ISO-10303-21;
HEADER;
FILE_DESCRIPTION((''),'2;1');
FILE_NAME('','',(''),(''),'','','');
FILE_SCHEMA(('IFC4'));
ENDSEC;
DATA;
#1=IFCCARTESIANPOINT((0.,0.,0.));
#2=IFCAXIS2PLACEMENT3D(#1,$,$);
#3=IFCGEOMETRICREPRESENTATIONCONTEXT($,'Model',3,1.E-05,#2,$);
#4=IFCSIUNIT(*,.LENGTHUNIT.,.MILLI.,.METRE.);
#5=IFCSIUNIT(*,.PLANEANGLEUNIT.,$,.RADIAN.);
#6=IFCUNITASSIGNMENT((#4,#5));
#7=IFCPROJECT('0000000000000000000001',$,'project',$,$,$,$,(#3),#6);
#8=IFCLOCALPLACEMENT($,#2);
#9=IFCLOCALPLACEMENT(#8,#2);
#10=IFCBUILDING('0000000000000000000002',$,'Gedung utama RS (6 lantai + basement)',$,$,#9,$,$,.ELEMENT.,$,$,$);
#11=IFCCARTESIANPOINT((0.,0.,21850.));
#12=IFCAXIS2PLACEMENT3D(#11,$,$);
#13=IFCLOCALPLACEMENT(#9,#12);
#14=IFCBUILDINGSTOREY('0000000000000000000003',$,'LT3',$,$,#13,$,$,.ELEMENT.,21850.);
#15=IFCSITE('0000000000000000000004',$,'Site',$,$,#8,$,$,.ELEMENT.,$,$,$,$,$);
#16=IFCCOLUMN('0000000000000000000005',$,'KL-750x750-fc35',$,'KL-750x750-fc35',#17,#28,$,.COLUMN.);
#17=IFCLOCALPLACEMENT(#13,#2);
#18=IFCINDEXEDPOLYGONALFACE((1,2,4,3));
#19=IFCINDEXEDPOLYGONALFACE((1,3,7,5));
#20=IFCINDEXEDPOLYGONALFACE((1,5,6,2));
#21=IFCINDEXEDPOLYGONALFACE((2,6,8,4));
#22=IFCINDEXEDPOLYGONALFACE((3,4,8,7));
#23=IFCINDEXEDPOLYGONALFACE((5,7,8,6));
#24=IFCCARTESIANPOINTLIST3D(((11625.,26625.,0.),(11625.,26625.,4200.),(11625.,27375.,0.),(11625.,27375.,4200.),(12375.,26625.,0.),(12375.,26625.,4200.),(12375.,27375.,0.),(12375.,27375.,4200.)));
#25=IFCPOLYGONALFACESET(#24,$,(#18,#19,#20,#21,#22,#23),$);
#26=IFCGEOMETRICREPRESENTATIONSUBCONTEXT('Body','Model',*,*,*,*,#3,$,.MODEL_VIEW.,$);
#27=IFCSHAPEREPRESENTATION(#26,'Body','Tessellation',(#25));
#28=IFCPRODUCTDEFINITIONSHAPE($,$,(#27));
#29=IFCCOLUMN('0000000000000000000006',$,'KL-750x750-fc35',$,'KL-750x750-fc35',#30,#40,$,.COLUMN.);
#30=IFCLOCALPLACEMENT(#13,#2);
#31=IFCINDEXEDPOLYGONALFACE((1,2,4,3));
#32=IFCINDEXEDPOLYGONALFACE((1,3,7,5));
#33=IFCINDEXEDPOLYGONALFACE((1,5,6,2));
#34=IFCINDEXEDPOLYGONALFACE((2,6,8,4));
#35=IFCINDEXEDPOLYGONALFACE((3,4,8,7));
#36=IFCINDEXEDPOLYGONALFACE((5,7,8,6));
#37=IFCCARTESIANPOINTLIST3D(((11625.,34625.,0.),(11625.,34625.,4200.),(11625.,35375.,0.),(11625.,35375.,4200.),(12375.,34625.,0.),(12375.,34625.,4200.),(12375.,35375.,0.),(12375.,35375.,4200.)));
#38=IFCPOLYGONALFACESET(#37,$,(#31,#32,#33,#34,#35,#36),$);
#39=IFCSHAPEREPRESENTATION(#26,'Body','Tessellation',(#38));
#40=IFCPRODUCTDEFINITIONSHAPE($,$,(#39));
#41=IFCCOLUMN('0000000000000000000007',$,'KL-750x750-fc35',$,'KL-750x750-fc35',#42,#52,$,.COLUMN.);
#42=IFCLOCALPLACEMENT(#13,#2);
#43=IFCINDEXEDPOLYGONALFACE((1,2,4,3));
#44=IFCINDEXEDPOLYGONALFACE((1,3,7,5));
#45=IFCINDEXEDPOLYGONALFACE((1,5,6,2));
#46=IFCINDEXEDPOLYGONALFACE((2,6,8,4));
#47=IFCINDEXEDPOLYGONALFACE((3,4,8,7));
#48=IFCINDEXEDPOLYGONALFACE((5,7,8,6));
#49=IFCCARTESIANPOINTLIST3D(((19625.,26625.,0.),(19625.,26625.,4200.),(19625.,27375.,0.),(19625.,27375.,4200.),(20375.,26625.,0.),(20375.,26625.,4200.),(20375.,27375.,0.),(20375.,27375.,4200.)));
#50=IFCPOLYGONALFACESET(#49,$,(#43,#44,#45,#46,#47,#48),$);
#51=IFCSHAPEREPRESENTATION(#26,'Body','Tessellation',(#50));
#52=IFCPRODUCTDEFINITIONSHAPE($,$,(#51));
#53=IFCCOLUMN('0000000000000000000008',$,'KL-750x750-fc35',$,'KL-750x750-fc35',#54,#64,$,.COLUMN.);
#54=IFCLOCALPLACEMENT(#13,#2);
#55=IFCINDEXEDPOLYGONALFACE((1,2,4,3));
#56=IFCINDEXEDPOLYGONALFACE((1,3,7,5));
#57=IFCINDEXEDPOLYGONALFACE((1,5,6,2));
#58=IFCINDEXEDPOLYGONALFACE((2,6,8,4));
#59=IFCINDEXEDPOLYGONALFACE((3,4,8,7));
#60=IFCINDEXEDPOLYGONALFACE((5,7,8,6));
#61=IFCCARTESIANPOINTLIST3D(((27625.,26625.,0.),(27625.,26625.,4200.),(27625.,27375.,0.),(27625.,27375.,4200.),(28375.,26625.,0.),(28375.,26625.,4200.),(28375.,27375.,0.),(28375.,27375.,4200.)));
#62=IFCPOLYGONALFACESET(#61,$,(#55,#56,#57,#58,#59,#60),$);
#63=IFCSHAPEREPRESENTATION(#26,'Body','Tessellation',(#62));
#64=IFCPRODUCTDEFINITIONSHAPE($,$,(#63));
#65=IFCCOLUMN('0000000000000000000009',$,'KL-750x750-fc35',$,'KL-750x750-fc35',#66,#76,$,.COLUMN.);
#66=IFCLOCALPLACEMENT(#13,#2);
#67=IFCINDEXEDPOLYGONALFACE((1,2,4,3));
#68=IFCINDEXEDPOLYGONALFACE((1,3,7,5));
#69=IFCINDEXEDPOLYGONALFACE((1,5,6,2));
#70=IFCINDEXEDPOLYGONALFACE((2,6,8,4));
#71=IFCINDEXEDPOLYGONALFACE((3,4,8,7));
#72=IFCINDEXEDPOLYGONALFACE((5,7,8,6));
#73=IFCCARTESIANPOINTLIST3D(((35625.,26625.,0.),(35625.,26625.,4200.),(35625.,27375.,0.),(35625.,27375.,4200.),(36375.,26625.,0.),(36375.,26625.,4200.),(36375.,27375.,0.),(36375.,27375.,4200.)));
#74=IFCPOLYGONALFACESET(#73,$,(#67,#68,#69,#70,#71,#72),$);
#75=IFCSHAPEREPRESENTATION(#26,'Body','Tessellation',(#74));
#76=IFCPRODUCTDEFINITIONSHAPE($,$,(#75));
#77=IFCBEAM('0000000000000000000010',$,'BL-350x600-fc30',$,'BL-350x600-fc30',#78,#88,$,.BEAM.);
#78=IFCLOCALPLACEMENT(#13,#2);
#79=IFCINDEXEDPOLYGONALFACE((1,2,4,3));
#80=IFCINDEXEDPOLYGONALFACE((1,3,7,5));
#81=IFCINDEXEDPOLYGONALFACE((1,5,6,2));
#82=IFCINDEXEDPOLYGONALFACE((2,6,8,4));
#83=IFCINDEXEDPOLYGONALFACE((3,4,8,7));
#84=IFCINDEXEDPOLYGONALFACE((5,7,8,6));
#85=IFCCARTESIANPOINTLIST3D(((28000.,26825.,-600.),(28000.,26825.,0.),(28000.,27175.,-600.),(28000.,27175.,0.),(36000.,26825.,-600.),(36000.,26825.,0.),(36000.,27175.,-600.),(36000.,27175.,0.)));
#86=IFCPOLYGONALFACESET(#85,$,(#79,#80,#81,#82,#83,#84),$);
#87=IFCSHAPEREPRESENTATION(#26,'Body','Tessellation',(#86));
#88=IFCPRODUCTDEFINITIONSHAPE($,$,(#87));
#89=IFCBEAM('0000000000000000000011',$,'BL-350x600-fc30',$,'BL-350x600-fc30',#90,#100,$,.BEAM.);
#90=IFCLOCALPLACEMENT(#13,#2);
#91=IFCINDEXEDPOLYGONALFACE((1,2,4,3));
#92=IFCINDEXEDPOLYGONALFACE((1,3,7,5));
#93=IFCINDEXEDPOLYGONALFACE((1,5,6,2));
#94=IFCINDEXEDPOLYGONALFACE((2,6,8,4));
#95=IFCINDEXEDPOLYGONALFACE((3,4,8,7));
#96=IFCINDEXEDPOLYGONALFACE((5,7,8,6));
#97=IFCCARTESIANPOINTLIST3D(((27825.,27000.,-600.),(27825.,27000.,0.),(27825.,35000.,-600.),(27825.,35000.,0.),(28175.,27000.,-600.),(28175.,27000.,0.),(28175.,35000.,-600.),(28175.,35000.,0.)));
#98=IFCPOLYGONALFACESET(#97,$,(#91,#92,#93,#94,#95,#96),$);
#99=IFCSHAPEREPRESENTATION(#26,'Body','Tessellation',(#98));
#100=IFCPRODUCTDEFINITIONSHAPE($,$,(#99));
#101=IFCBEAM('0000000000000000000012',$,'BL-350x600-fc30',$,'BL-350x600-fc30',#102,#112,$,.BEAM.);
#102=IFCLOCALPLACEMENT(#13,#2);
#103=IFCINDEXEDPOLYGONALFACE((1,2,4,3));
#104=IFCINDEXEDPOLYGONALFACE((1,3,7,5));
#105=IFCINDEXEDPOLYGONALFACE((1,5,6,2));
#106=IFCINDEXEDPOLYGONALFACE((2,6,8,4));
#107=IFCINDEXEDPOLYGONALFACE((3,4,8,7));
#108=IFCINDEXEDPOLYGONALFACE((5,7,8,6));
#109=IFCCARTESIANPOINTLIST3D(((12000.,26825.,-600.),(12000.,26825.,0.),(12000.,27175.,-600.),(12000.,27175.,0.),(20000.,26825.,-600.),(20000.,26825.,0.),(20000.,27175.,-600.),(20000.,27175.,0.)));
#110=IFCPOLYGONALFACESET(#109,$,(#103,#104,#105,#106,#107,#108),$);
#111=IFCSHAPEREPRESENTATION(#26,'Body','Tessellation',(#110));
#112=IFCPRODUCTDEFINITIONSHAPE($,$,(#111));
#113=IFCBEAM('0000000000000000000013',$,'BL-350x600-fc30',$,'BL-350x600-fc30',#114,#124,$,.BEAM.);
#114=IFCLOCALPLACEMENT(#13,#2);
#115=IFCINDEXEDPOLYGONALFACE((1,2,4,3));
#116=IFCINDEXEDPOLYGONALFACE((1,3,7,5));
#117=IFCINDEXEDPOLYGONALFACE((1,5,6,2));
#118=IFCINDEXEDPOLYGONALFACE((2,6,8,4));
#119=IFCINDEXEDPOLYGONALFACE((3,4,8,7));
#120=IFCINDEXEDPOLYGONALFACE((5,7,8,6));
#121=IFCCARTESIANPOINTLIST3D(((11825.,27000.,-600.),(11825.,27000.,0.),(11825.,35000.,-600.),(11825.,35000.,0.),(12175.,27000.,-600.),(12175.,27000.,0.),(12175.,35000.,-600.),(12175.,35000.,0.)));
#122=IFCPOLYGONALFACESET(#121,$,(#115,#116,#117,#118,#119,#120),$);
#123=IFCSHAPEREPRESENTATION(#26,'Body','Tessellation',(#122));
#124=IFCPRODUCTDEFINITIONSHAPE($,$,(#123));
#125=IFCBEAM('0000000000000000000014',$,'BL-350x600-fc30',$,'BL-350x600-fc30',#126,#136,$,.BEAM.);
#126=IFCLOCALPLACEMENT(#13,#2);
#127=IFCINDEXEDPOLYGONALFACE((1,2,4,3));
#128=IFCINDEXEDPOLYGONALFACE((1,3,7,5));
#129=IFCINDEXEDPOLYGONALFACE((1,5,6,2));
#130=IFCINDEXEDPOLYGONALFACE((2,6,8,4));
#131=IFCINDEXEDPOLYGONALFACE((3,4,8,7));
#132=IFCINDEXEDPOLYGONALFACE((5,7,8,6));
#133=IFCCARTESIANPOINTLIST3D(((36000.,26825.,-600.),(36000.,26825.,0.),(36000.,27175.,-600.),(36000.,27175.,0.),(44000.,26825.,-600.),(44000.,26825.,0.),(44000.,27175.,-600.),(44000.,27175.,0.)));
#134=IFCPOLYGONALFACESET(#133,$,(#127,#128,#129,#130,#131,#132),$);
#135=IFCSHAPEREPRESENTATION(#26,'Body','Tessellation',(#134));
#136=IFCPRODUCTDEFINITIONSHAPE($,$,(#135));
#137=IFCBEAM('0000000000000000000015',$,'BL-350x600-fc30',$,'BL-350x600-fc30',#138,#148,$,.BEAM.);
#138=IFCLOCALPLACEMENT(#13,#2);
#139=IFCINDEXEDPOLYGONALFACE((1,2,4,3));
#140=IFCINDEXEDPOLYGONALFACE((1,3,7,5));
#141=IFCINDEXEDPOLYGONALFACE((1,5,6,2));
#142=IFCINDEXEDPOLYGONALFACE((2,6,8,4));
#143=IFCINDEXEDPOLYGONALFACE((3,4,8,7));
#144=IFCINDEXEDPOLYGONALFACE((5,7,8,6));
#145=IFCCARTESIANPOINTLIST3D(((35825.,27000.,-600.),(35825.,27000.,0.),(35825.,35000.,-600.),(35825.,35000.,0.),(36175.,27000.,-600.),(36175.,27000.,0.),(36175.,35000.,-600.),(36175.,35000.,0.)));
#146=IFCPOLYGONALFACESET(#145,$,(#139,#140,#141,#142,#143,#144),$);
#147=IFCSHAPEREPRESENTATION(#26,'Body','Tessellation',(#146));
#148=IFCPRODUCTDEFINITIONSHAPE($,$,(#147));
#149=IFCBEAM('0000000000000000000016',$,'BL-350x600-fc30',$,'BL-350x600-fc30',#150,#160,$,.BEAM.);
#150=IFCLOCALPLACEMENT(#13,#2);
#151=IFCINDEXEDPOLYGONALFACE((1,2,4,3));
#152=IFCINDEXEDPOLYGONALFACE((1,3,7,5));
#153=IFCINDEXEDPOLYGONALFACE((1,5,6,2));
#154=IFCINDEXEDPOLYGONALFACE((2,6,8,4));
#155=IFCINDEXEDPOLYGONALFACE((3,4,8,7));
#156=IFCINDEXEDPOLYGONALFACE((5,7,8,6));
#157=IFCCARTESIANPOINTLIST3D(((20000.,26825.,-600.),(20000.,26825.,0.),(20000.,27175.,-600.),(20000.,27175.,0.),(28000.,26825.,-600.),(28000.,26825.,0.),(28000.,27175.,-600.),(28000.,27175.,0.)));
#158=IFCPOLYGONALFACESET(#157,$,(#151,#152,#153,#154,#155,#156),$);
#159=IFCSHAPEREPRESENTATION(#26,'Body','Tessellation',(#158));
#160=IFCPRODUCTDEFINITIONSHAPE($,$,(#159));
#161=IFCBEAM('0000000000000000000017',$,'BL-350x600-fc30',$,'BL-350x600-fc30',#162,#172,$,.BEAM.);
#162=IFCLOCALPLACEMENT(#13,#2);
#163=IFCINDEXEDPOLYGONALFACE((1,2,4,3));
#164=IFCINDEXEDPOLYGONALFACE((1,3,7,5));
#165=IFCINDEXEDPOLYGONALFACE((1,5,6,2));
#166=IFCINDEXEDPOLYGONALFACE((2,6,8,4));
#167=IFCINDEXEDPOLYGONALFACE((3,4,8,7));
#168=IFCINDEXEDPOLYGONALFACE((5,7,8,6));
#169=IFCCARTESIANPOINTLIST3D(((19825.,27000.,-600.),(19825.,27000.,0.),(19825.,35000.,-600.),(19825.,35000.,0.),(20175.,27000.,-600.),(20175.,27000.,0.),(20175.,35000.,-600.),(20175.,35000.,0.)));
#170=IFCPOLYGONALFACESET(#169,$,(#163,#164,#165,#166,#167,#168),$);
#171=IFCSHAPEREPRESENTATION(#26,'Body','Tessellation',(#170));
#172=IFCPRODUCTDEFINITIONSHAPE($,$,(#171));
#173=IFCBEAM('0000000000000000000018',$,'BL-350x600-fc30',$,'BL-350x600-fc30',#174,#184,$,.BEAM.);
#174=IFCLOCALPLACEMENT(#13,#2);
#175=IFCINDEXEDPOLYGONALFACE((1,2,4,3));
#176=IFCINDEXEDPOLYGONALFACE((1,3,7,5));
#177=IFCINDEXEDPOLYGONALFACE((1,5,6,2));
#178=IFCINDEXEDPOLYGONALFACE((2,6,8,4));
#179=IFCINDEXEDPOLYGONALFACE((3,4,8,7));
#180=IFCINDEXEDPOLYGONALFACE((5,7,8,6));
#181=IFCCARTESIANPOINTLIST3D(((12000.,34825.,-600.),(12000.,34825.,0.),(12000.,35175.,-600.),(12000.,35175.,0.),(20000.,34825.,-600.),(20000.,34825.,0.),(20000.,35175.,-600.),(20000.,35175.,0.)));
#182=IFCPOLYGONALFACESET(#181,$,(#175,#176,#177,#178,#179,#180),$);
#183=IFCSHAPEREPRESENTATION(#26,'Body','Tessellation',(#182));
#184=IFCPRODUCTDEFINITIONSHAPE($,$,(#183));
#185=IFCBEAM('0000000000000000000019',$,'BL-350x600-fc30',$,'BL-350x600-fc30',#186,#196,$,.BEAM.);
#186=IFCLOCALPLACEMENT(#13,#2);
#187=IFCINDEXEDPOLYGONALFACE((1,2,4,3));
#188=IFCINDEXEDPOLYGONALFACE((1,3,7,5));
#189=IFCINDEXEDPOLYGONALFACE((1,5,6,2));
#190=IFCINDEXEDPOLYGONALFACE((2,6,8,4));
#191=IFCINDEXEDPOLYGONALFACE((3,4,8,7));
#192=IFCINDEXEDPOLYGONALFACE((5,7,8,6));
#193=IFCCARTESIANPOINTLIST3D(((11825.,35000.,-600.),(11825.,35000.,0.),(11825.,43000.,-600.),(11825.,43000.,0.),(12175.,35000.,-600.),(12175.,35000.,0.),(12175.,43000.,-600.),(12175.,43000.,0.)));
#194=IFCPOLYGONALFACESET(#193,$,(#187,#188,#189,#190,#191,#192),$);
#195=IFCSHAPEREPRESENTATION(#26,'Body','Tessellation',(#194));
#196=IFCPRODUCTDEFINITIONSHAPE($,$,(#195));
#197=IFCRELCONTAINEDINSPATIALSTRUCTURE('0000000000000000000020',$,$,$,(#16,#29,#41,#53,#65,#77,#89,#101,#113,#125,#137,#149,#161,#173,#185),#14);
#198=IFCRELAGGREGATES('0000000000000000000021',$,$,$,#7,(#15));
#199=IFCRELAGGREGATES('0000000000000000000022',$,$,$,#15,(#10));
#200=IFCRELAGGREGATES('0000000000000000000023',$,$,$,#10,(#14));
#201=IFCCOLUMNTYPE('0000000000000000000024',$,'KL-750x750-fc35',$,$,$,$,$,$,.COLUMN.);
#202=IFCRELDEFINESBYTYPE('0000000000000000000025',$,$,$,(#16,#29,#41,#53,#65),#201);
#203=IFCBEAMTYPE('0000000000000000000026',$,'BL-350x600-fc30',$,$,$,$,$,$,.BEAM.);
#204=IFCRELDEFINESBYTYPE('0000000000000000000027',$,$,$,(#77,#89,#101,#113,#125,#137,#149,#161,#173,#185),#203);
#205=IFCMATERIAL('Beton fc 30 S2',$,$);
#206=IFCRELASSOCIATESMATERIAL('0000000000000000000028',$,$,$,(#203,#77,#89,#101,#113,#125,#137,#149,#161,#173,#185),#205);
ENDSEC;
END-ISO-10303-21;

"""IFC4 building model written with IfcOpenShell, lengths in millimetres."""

from ifc_helpers import new_model, si_unit, frame, origin, origin_2d, place, context, subcontext, project, spatial, rectangle, extrude, material, material_profile, profile_set, profile_usage, type_object, element, save


model = new_model("IFC4")

# Units and contexts
model_context = context("Model", 3, precision=1e-05, world=origin())
body_context = subcontext(model_context, "Body", "Model", "MODEL_VIEW")
ifc_project = project(units=[si_unit("LENGTHUNIT", "METRE", prefix="MILLI"), si_unit("PLANEANGLEUNIT", "RADIAN")], contexts=[model_context])

# Site, building, storey
site_placement = place(None, origin())
site = spatial("IfcSite", under=ifc_project, at=site_placement, Name="Site", CompositionType="ELEMENT")
building_placement = place(site_placement, origin())
building = spatial("IfcBuilding", under=site, at=building_placement, Name="Gedung utama RS (6 lantai + basement)", CompositionType="ELEMENT")
storey_placement = place(building_placement, frame((0.0, 0.0, 21850.0)))
storey = spatial("IfcBuildingStorey", under=building, at=storey_placement, Name="LT3", CompositionType="ELEMENT", Elevation=21850.0)

# Columns
ifc_material_profile_1 = material_profile(None, rectangle(XDim=750.0, YDim=750.0, at=origin_2d()), Name="KL-750x750-fc35")
ifc_profile_set_1 = profile_set([ifc_material_profile_1], Name="KL-750x750-fc35")
ifc_profile_usage_1 = profile_usage(ifc_profile_set_1, cardinal=5)
column_type = type_object("IfcColumnType", Name="KL-750x750-fc35", PredefinedType="COLUMN", material=ifc_profile_set_1)
for number, where, z_axis, x_axis, name in (
    (1, (12000.0, 27000.0, 0.0), (0.0, 0.0, 1.0), (1.0, 0.0, 0.0), "KL-750x750-fc35"),
    (2, (12000.0, 35000.0, 0.0), (0.0, 0.0, 1.0), (1.0, 0.0, 0.0), "KL-750x750-fc35"),
    (3, (20000.0, 27000.0, 0.0), (0.0, 0.0, 1.0), (1.0, 0.0, 0.0), "KL-750x750-fc35"),
    (4, (28000.0, 27000.0, 0.0), (0.0, 0.0, 1.0), (1.0, 0.0, 0.0), "KL-750x750-fc35"),
    (5, (36000.0, 27000.0, 0.0), (0.0, 0.0, 1.0), (1.0, 0.0, 0.0), "KL-750x750-fc35"),
):
    element("IfcColumn", number, at=place(storey_placement, frame(where, z_axis=z_axis, x_axis=x_axis)), inside=storey, type_object=column_type, material=ifc_profile_usage_1, Name=name, ObjectType="KL-750x750-fc35", PredefinedType="COLUMN", context=body_context, shape_type="SweptSolid", body=[
        extrude(rectangle(XDim=750.0, YDim=750.0, at=origin_2d()), origin(), (0.0, 0.0, 1.0), 4200.0),
    ])

# Beams
ifc_material_1 = material(Name="Beton fc 30 S2")
ifc_material_profile_2 = material_profile(ifc_material_1, rectangle(XDim=350.0, YDim=600.0, at=origin_2d()), Name="BL-350x600-fc30")
ifc_profile_set_2 = profile_set([ifc_material_profile_2], Name="BL-350x600-fc30")
ifc_profile_usage_2 = profile_usage(ifc_profile_set_2, cardinal=8)
beam_type = type_object("IfcBeamType", Name="BL-350x600-fc30", PredefinedType="BEAM", material=ifc_profile_set_2)
beam_1_placement = place(storey_placement, frame((28000.0, 27000.0, -300.0)))
element("IfcBeam", 6, at=beam_1_placement, inside=storey, type_object=beam_type, material=ifc_profile_usage_2, Name="BL-350x600-fc30", ObjectType="BL-350x600-fc30", PredefinedType="BEAM", context=body_context, shape_type="SweptSolid", body=[
    extrude(rectangle(XDim=350.0, YDim=600.0, at=origin_2d()), frame((0.0, 0.0, 0.0), z_axis=(1.0, 0.0, 0.0), x_axis=(0.0, 1.0, 0.0)), (0.0, 0.0, 1.0), 8000.0),
])
beam_2_placement = place(storey_placement, frame((28000.0, 27000.0, -300.0)))
element("IfcBeam", 7, at=beam_2_placement, inside=storey, type_object=beam_type, material=ifc_profile_usage_2, Name="BL-350x600-fc30", ObjectType="BL-350x600-fc30", PredefinedType="BEAM", context=body_context, shape_type="SweptSolid", body=[
    extrude(rectangle(XDim=350.0, YDim=600.0, at=origin_2d()), frame((0.0, 0.0, 0.0), z_axis=(0.0, 1.0, 0.0), x_axis=(-1.0, 0.0, 0.0)), (0.0, 0.0, 1.0), 8000.0),
])
beam_3_placement = place(storey_placement, frame((12000.0, 27000.0, -300.0)))
element("IfcBeam", 8, at=beam_3_placement, inside=storey, type_object=beam_type, material=ifc_profile_usage_2, Name="BL-350x600-fc30", ObjectType="BL-350x600-fc30", PredefinedType="BEAM", context=body_context, shape_type="SweptSolid", body=[
    extrude(rectangle(XDim=350.0, YDim=600.0, at=origin_2d()), frame((0.0, 0.0, 0.0), z_axis=(1.0, 0.0, 0.0), x_axis=(0.0, 1.0, 0.0)), (0.0, 0.0, 1.0), 8000.0),
])
beam_4_placement = place(storey_placement, frame((12000.0, 27000.0, -300.0)))
element("IfcBeam", 9, at=beam_4_placement, inside=storey, type_object=beam_type, material=ifc_profile_usage_2, Name="BL-350x600-fc30", ObjectType="BL-350x600-fc30", PredefinedType="BEAM", context=body_context, shape_type="SweptSolid", body=[
    extrude(rectangle(XDim=350.0, YDim=600.0, at=origin_2d()), frame((0.0, 0.0, 0.0), z_axis=(0.0, 1.0, 0.0), x_axis=(-1.0, 0.0, 0.0)), (0.0, 0.0, 1.0), 8000.0),
])
beam_5_placement = place(storey_placement, frame((36000.0, 27000.0, -300.0)))
element("IfcBeam", 10, at=beam_5_placement, inside=storey, type_object=beam_type, material=ifc_profile_usage_2, Name="BL-350x600-fc30", ObjectType="BL-350x600-fc30", PredefinedType="BEAM", context=body_context, shape_type="SweptSolid", body=[
    extrude(rectangle(XDim=350.0, YDim=600.0, at=origin_2d()), frame((0.0, 0.0, 0.0), z_axis=(1.0, 0.0, 0.0), x_axis=(0.0, 1.0, 0.0)), (0.0, 0.0, 1.0), 8000.0),
])
beam_6_placement = place(storey_placement, frame((36000.0, 27000.0, -300.0)))
element("IfcBeam", 11, at=beam_6_placement, inside=storey, type_object=beam_type, material=ifc_profile_usage_2, Name="BL-350x600-fc30", ObjectType="BL-350x600-fc30", PredefinedType="BEAM", context=body_context, shape_type="SweptSolid", body=[
    extrude(rectangle(XDim=350.0, YDim=600.0, at=origin_2d()), frame((0.0, 0.0, 0.0), z_axis=(0.0, 1.0, 0.0), x_axis=(-1.0, 0.0, 0.0)), (0.0, 0.0, 1.0), 8000.0),
])
beam_7_placement = place(storey_placement, frame((20000.0, 27000.0, -300.0)))
element("IfcBeam", 12, at=beam_7_placement, inside=storey, type_object=beam_type, material=ifc_profile_usage_2, Name="BL-350x600-fc30", ObjectType="BL-350x600-fc30", PredefinedType="BEAM", context=body_context, shape_type="SweptSolid", body=[
    extrude(rectangle(XDim=350.0, YDim=600.0, at=origin_2d()), frame((0.0, 0.0, 0.0), z_axis=(1.0, 0.0, 0.0), x_axis=(0.0, 1.0, 0.0)), (0.0, 0.0, 1.0), 8000.0),
])
beam_8_placement = place(storey_placement, frame((20000.0, 27000.0, -300.0)))
element("IfcBeam", 13, at=beam_8_placement, inside=storey, type_object=beam_type, material=ifc_profile_usage_2, Name="BL-350x600-fc30", ObjectType="BL-350x600-fc30", PredefinedType="BEAM", context=body_context, shape_type="SweptSolid", body=[
    extrude(rectangle(XDim=350.0, YDim=600.0, at=origin_2d()), frame((0.0, 0.0, 0.0), z_axis=(0.0, 1.0, 0.0), x_axis=(-1.0, 0.0, 0.0)), (0.0, 0.0, 1.0), 8000.0),
])
beam_9_placement = place(storey_placement, frame((12000.0, 35000.0, -300.0)))
element("IfcBeam", 14, at=beam_9_placement, inside=storey, type_object=beam_type, material=ifc_profile_usage_2, Name="BL-350x600-fc30", ObjectType="BL-350x600-fc30", PredefinedType="BEAM", context=body_context, shape_type="SweptSolid", body=[
    extrude(rectangle(XDim=350.0, YDim=600.0, at=origin_2d()), frame((0.0, 0.0, 0.0), z_axis=(1.0, 0.0, 0.0), x_axis=(0.0, 1.0, 0.0)), (0.0, 0.0, 1.0), 8000.0),
])
beam_10_placement = place(storey_placement, frame((12000.0, 35000.0, -300.0)))
element("IfcBeam", 15, at=beam_10_placement, inside=storey, type_object=beam_type, material=ifc_profile_usage_2, Name="BL-350x600-fc30", ObjectType="BL-350x600-fc30", PredefinedType="BEAM", context=body_context, shape_type="SweptSolid", body=[
    extrude(rectangle(XDim=350.0, YDim=600.0, at=origin_2d()), frame((0.0, 0.0, 0.0), z_axis=(0.0, 1.0, 0.0), x_axis=(-1.0, 0.0, 0.0)), (0.0, 0.0, 1.0), 8000.0),
])

save(model, "model.ifc")
